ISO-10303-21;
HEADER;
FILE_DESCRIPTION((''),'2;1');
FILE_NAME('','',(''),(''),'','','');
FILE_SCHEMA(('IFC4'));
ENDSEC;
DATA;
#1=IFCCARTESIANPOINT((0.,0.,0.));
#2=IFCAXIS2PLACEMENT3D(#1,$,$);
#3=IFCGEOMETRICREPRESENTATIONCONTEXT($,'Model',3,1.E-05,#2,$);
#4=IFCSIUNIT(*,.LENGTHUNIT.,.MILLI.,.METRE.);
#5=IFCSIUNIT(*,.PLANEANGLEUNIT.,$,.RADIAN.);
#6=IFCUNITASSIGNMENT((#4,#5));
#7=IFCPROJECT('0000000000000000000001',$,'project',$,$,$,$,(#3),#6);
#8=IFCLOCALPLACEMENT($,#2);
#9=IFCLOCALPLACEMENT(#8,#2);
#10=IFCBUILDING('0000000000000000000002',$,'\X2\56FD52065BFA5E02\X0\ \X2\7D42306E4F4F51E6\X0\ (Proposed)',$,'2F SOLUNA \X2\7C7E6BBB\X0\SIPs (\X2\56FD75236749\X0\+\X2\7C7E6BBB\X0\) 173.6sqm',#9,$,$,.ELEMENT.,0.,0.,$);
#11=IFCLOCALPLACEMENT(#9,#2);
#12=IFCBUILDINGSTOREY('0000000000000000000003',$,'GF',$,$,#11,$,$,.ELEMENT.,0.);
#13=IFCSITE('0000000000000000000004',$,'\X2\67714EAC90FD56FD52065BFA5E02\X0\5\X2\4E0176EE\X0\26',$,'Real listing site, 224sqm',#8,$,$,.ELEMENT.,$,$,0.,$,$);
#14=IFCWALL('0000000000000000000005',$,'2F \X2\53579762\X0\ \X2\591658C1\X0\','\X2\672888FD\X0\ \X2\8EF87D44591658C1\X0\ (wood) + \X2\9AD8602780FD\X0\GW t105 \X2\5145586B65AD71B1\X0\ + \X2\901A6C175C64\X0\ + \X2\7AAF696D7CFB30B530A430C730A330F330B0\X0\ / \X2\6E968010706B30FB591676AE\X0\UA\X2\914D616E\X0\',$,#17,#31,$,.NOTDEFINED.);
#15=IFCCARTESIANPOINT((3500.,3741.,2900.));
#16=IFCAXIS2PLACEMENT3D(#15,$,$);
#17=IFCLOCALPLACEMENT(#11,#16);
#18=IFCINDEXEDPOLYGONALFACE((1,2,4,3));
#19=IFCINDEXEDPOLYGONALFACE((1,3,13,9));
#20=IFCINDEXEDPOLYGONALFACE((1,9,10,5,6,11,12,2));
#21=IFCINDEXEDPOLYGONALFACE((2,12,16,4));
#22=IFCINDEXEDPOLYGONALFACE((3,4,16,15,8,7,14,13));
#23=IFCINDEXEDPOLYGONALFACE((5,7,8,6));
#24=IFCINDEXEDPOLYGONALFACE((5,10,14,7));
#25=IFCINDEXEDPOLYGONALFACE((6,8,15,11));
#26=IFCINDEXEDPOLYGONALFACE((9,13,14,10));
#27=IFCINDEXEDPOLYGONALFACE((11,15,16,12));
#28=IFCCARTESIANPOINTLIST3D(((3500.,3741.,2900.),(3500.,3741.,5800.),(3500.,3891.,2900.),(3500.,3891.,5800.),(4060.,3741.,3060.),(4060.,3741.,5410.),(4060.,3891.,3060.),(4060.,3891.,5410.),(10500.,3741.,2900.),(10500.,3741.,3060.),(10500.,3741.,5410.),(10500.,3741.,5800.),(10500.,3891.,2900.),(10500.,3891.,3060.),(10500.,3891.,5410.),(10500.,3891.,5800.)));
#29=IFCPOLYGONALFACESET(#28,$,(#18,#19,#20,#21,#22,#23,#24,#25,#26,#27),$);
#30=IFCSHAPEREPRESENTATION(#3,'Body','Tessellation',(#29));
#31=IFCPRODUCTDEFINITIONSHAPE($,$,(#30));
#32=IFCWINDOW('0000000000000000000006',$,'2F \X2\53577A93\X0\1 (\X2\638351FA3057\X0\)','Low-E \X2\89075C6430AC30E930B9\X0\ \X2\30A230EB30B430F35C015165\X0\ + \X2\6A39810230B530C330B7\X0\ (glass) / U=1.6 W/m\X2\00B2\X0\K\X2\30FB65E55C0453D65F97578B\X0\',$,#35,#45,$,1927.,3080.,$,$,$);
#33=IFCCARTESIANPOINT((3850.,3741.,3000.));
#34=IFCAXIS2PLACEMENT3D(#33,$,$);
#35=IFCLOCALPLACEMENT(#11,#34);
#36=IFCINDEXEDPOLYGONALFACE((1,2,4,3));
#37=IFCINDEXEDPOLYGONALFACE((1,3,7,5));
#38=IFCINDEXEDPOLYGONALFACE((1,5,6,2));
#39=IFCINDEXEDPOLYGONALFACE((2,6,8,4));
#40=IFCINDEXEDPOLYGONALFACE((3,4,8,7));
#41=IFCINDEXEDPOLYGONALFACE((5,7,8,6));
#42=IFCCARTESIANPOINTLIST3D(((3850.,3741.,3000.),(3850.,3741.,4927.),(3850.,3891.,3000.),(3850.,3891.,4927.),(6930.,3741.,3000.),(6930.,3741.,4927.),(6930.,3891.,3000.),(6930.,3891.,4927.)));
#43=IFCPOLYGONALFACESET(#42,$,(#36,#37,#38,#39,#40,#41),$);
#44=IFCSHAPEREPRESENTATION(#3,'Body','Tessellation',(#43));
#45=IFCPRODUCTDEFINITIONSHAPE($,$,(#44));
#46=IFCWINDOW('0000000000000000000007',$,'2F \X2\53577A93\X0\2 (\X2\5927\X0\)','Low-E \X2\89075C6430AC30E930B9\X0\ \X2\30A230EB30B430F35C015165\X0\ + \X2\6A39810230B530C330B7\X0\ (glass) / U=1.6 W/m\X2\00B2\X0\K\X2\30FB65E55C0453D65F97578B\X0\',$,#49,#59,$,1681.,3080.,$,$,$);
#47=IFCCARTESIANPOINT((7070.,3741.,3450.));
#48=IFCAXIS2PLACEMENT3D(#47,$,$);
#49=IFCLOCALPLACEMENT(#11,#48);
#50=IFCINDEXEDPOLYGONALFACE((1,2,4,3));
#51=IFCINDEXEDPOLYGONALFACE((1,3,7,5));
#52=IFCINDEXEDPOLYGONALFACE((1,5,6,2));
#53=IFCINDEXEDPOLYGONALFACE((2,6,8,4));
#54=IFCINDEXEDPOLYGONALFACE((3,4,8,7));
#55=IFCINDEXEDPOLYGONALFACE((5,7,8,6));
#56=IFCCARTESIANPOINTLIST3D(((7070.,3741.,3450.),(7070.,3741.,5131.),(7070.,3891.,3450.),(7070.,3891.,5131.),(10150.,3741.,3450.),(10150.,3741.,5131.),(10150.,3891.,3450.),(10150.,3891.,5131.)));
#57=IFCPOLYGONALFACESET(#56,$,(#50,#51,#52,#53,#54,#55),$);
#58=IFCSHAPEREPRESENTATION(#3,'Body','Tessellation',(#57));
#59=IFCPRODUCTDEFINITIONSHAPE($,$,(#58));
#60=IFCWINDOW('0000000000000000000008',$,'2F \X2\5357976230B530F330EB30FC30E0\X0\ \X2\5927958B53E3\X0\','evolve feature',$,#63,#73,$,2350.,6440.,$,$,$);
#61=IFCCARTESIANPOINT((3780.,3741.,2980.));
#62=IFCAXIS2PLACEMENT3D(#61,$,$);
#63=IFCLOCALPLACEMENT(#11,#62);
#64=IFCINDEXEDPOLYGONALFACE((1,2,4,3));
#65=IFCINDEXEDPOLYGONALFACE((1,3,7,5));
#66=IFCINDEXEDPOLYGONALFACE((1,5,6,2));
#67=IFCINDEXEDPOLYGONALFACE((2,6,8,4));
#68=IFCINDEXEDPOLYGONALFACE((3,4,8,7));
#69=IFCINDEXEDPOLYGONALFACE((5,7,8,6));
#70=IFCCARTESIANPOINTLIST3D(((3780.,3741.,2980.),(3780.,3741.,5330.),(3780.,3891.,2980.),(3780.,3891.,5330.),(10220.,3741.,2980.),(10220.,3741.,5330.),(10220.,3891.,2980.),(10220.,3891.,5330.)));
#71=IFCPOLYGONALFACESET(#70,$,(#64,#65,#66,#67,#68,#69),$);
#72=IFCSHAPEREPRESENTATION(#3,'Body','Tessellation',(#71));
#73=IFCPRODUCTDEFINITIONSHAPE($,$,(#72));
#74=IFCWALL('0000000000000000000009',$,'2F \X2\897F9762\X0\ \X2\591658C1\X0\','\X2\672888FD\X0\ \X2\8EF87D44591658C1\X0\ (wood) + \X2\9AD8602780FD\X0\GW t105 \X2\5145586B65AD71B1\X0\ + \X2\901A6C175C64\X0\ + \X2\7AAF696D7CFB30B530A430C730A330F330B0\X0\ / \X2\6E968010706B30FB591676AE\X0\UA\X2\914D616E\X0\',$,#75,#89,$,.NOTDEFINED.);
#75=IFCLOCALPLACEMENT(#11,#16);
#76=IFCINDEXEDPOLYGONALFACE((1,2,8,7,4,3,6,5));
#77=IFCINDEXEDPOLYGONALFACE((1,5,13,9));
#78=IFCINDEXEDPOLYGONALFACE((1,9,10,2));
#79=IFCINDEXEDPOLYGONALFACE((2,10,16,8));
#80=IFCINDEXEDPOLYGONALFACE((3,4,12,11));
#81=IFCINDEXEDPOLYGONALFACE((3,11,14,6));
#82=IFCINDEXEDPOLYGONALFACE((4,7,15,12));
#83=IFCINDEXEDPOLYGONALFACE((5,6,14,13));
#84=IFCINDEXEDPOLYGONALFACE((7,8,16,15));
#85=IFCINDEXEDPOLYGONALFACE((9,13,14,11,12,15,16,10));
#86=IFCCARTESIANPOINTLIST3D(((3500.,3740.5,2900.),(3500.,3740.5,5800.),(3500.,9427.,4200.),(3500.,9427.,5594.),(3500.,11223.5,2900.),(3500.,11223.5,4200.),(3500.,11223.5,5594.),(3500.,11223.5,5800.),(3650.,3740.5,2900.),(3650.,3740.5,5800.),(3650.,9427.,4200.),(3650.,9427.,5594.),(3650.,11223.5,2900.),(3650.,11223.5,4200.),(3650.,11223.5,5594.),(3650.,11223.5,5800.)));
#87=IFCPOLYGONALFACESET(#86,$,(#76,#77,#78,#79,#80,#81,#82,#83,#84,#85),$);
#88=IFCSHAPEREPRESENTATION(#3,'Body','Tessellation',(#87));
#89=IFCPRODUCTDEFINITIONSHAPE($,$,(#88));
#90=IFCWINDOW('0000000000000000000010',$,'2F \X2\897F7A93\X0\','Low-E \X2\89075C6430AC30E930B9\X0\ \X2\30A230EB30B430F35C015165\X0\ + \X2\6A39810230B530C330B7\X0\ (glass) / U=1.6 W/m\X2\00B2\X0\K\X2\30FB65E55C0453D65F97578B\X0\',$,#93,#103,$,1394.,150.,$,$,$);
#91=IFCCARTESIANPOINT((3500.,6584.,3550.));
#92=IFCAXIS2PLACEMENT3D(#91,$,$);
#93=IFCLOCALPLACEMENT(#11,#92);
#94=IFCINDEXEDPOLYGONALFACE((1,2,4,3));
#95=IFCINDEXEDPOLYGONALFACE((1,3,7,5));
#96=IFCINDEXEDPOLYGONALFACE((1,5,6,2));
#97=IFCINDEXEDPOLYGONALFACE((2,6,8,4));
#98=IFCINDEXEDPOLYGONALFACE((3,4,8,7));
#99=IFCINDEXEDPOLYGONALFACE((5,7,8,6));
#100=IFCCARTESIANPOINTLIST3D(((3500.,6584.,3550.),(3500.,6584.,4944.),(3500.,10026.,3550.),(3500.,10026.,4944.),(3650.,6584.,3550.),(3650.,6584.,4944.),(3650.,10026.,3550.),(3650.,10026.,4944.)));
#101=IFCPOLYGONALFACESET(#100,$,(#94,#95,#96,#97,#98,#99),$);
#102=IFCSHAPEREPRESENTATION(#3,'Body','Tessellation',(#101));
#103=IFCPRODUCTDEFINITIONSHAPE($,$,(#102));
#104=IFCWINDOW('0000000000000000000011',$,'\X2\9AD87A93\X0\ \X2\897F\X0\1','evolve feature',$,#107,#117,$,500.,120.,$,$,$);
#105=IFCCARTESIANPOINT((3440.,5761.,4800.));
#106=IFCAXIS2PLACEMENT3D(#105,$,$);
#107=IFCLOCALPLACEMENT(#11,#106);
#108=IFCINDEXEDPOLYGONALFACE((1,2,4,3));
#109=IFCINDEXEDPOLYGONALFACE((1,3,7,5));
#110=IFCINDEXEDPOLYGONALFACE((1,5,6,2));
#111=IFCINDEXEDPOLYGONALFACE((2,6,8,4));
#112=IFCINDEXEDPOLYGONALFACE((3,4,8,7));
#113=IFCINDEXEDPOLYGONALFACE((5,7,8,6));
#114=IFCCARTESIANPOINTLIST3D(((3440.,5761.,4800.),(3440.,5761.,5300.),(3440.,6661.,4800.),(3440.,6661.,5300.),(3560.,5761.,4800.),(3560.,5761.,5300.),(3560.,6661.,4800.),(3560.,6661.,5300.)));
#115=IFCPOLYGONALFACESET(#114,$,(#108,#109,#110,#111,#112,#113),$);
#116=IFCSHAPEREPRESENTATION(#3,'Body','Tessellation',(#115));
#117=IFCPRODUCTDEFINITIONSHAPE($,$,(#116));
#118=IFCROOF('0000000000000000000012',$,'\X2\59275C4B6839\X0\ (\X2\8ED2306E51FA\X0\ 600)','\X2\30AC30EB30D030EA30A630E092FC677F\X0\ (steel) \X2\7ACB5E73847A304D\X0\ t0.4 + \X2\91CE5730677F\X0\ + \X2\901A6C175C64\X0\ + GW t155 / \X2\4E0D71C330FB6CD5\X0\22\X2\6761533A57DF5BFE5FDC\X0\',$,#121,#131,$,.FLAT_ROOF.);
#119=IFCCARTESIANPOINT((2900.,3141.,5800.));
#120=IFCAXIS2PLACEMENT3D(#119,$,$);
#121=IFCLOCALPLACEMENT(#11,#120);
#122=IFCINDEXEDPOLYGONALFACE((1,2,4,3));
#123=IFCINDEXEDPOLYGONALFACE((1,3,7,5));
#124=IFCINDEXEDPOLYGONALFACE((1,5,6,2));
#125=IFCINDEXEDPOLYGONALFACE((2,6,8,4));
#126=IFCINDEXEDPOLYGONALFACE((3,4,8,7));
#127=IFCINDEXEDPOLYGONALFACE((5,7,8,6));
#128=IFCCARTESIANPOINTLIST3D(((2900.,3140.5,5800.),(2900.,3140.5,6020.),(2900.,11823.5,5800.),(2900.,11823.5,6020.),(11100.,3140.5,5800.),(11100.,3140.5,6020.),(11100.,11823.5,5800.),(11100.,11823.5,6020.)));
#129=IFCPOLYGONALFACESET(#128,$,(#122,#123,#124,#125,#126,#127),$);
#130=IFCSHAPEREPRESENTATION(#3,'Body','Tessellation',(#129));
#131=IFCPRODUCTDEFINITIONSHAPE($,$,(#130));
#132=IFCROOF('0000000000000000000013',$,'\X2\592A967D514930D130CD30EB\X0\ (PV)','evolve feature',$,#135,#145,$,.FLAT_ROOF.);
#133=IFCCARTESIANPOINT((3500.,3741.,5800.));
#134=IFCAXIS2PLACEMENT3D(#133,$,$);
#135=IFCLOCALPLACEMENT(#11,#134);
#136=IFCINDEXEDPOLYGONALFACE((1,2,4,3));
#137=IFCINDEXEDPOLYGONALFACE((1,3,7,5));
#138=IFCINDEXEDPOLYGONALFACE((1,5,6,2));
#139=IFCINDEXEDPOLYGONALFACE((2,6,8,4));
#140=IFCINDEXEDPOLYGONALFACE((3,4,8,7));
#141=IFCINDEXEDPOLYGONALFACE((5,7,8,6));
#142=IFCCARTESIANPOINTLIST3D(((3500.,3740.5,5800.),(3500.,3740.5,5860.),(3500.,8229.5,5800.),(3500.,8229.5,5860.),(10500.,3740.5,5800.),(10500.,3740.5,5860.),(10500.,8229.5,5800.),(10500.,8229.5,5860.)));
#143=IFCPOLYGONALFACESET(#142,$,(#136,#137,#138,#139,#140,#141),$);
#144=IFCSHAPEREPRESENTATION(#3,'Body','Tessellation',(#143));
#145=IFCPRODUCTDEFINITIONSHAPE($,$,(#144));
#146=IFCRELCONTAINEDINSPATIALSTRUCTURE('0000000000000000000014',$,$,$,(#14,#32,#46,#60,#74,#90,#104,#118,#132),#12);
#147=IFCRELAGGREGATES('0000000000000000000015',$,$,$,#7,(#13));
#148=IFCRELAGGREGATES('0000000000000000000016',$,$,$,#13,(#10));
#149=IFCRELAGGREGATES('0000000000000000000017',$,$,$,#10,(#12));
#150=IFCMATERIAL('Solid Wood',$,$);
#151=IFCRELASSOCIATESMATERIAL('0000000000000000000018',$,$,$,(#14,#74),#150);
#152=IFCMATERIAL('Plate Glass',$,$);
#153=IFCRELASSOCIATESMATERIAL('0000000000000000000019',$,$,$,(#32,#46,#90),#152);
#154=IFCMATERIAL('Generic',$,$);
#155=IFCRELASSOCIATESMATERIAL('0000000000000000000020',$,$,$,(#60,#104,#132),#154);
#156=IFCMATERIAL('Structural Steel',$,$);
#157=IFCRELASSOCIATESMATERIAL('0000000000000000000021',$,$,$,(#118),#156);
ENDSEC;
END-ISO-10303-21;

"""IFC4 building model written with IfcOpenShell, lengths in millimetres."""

from ifc_helpers import new_model, si_unit, frame, frame_2d, origin, place, context, project, spatial, rectangle, extrude, material, element, fill, save


model = new_model("IFC4")

# Units and contexts
model_context = context("Model", 3, precision=1e-05, world=origin())
ifc_project = project(units=[si_unit("LENGTHUNIT", "METRE", prefix="MILLI"), si_unit("PLANEANGLEUNIT", "RADIAN")], contexts=[model_context])

# Site, building, storey
site_placement = place(None, origin())
site = spatial("IfcSite", under=ifc_project, at=site_placement, Name="東京都国分寺市5丁目26", ObjectType="Real listing site, 224sqm", CompositionType="ELEMENT", RefElevation=0.0)
building_placement = place(site_placement, origin())
building = spatial("IfcBuilding", under=site, at=building_placement, Name="国分寺市 終の住処 (Proposed)", ObjectType="2F SOLUNA 籾殻SIPs (国産杉+籾殻) 173.6sqm", CompositionType="ELEMENT", ElevationOfRefHeight=0.0, ElevationOfTerrain=0.0)
storey_placement = place(building_placement, origin())
storey = spatial("IfcBuildingStorey", under=building, at=storey_placement, Name="GF", CompositionType="ELEMENT", Elevation=0.0)

# Shared definitions
ifc_material_1 = material(Name="Solid Wood")
ifc_material_2 = material(Name="Generic")

# Shared definitions
ifc_material_3 = material(Name="Plate Glass")

# Walls, openings, windows
wall_1_placement = place(storey_placement, frame((3500.0, 3741.0, 2900.0)))
wall_1 = element("IfcWall", 1, at=wall_1_placement, inside=storey, material=ifc_material_1, Name="2F 南面 外壁", Description="木製 軸組外壁 (wood) + 高性能GW t105 充填断熱 + 通気層 + 窯業系サイディング / 準耐火・外皮UA配慮", PredefinedType="NOTDEFINED", context=model_context, shape_type="SweptSolid", body=[
    extrude(rectangle(XDim=7000.0, YDim=150.0, at=frame_2d((3500.0, 75.0))), frame((3500.0, 3741.0, 2900.0)), (0.0, 0.0, 1.0), 2900.0),
])
opening_1_placement = place(storey_placement, frame((3850.0, 3741.0, 3000.0)))
opening_1 = element("IfcOpeningElement", 2, at=opening_1_placement, cuts=wall_1, PredefinedType="NOTDEFINED", context=model_context, shape_type="SweptSolid", body=[
    extrude(rectangle(XDim=3080.0, YDim=150.0, at=frame_2d((1540.0, 75.0))), frame((3850.0, 3741.0, 3000.0)), (0.0, 0.0, 1.0), 1927.0),
])
opening_2_placement = place(storey_placement, frame((7070.0, 3741.0, 3450.0)))
opening_2 = element("IfcOpeningElement", 3, at=opening_2_placement, cuts=wall_1, PredefinedType="NOTDEFINED", context=model_context, shape_type="SweptSolid", body=[
    extrude(rectangle(XDim=3080.0, YDim=150.0, at=frame_2d((1540.0, 75.0))), frame((7070.0, 3741.0, 3450.0)), (0.0, 0.0, 1.0), 1681.0),
])
opening_3_placement = place(storey_placement, frame((3780.0, 3741.0, 2980.0)))
opening_3 = element("IfcOpeningElement", 4, at=opening_3_placement, cuts=wall_1, PredefinedType="NOTDEFINED", context=model_context, shape_type="SweptSolid", body=[
    extrude(rectangle(XDim=6440.0, YDim=150.0, at=frame_2d((3220.0, 75.0))), frame((3780.0, 3741.0, 2980.0)), (0.0, 0.0, 1.0), 2350.0),
])
window_1_placement = place(storey_placement, frame((3850.0, 3741.0, 3000.0)))
window_1 = element("IfcWindow", 5, at=window_1_placement, inside=storey, material=ifc_material_3, Name="2F 南窓1 (掃出し)", Description="Low-E 複層ガラス アルゴン封入 + 樹脂サッシ (glass) / U=1.6 W/m²K・日射取得型", OverallHeight=1927.0, OverallWidth=3080.0, context=model_context, shape_type="SweptSolid", body=[
    extrude(rectangle(XDim=3080.0, YDim=150.0, at=frame_2d((1540.0, 75.0))), frame((3850.0, 3741.0, 3000.0)), (0.0, 0.0, 1.0), 1927.0),
])
fill(opening_1, window_1)
window_2_placement = place(storey_placement, frame((7070.0, 3741.0, 3450.0)))
window_2 = element("IfcWindow", 6, at=window_2_placement, inside=storey, material=ifc_material_3, Name="2F 南窓2 (大)", Description="Low-E 複層ガラス アルゴン封入 + 樹脂サッシ (glass) / U=1.6 W/m²K・日射取得型", OverallHeight=1681.0, OverallWidth=3080.0, context=model_context, shape_type="SweptSolid", body=[
    extrude(rectangle(XDim=3080.0, YDim=150.0, at=frame_2d((1540.0, 75.0))), frame((7070.0, 3741.0, 3450.0)), (0.0, 0.0, 1.0), 1681.0),
])
fill(opening_2, window_2)
window_3_placement = place(storey_placement, frame((3780.0, 3741.0, 2980.0)))
window_3 = element("IfcWindow", 7, at=window_3_placement, inside=storey, material=ifc_material_2, Name="2F 南面サンルーム 大開口", Description="evolve feature", OverallHeight=2350.0, OverallWidth=6440.0, context=model_context, shape_type="SweptSolid", body=[
    extrude(rectangle(XDim=6440.0, YDim=150.0, at=frame_2d((3220.0, 75.0))), frame((3780.0, 3741.0, 2980.0)), (0.0, 0.0, 1.0), 2350.0),
])
fill(opening_3, window_3)
wall_2_placement = place(storey_placement, frame((3500.0, 3741.0, 2900.0)))
wall_2 = element("IfcWall", 8, at=wall_2_placement, inside=storey, material=ifc_material_1, Name="2F 西面 外壁", Description="木製 軸組外壁 (wood) + 高性能GW t105 充填断熱 + 通気層 + 窯業系サイディング / 準耐火・外皮UA配慮", PredefinedType="NOTDEFINED", context=model_context, shape_type="SweptSolid", body=[
    extrude(rectangle(XDim=150.0, YDim=7483.0, at=frame_2d((75.0, 3741.0))), frame((3500.0, 3741.0, 2900.0)), (0.0, 0.0, 1.0), 2900.0),
])
opening_4_placement = place(storey_placement, frame((3500.0, 6584.0, 3550.0)))
opening_4 = element("IfcOpeningElement", 9, at=opening_4_placement, cuts=wall_2, PredefinedType="NOTDEFINED", context=model_context, shape_type="SweptSolid", body=[
    extrude(rectangle(XDim=150.0, YDim=3442.0, at=frame_2d((75.0, 1721.0))), frame((3500.0, 6584.0, 3550.0)), (0.0, 0.0, 1.0), 1394.0),
])
opening_5_placement = place(storey_placement, frame((3440.0, 5761.0, 4800.0)))
opening_5 = element("IfcOpeningElement", 10, at=opening_5_placement, cuts=wall_2, PredefinedType="NOTDEFINED", context=model_context, shape_type="SweptSolid", body=[
    extrude(rectangle(XDim=120.0, YDim=900.0, at=frame_2d((60.0, 450.0))), frame((3440.0, 5761.0, 4800.0)), (0.0, 0.0, 1.0), 500.0),
])
window_4_placement = place(storey_placement, frame((3500.0, 6584.0, 3550.0)))
window_4 = element("IfcWindow", 11, at=window_4_placement, inside=storey, material=ifc_material_3, Name="2F 西窓", Description="Low-E 複層ガラス アルゴン封入 + 樹脂サッシ (glass) / U=1.6 W/m²K・日射取得型", OverallHeight=1394.0, OverallWidth=150.0, context=model_context, shape_type="SweptSolid", body=[
    extrude(rectangle(XDim=150.0, YDim=3442.0, at=frame_2d((75.0, 1721.0))), frame((3500.0, 6584.0, 3550.0)), (0.0, 0.0, 1.0), 1394.0),
])
fill(opening_4, window_4)
window_5_placement = place(storey_placement, frame((3440.0, 5761.0, 4800.0)))
window_5 = element("IfcWindow", 12, at=window_5_placement, inside=storey, material=ifc_material_2, Name="高窓 西1", Description="evolve feature", OverallHeight=500.0, OverallWidth=120.0, context=model_context, shape_type="SweptSolid", body=[
    extrude(rectangle(XDim=120.0, YDim=900.0, at=frame_2d((60.0, 450.0))), frame((3440.0, 5761.0, 4800.0)), (0.0, 0.0, 1.0), 500.0),
])
fill(opening_5, window_5)

# Roofs
ifc_material_4 = material(Name="Structural Steel")
roof_1_placement = place(storey_placement, frame((2900.0, 3141.0, 5800.0)))
element("IfcRoof", 13, at=roof_1_placement, inside=storey, material=ifc_material_4, Name="大屋根 (軒の出 600)", Description="ガルバリウム鋼板 (steel) 立平葺き t0.4 + 野地板 + 通気層 + GW t155 / 不燃・法22条区域対応", PredefinedType="FLAT_ROOF", context=model_context, shape_type="SweptSolid", body=[
    extrude(rectangle(XDim=8200.0, YDim=8683.0, at=frame_2d((4100.0, 4341.0))), frame((2900.0, 3141.0, 5800.0)), (0.0, 0.0, 1.0), 220.0),
])
roof_2_placement = place(storey_placement, frame((3500.0, 3741.0, 5800.0)))
element("IfcRoof", 14, at=roof_2_placement, inside=storey, material=ifc_material_2, Name="太陽光パネル (PV)", Description="evolve feature", PredefinedType="FLAT_ROOF", context=model_context, shape_type="SweptSolid", body=[
    extrude(rectangle(XDim=7000.0, YDim=4489.0, at=frame_2d((3500.0, 2244.0))), frame((3500.0, 3741.0, 5800.0)), (0.0, 0.0, 1.0), 60.0),
])

save(model, "model.ifc")
